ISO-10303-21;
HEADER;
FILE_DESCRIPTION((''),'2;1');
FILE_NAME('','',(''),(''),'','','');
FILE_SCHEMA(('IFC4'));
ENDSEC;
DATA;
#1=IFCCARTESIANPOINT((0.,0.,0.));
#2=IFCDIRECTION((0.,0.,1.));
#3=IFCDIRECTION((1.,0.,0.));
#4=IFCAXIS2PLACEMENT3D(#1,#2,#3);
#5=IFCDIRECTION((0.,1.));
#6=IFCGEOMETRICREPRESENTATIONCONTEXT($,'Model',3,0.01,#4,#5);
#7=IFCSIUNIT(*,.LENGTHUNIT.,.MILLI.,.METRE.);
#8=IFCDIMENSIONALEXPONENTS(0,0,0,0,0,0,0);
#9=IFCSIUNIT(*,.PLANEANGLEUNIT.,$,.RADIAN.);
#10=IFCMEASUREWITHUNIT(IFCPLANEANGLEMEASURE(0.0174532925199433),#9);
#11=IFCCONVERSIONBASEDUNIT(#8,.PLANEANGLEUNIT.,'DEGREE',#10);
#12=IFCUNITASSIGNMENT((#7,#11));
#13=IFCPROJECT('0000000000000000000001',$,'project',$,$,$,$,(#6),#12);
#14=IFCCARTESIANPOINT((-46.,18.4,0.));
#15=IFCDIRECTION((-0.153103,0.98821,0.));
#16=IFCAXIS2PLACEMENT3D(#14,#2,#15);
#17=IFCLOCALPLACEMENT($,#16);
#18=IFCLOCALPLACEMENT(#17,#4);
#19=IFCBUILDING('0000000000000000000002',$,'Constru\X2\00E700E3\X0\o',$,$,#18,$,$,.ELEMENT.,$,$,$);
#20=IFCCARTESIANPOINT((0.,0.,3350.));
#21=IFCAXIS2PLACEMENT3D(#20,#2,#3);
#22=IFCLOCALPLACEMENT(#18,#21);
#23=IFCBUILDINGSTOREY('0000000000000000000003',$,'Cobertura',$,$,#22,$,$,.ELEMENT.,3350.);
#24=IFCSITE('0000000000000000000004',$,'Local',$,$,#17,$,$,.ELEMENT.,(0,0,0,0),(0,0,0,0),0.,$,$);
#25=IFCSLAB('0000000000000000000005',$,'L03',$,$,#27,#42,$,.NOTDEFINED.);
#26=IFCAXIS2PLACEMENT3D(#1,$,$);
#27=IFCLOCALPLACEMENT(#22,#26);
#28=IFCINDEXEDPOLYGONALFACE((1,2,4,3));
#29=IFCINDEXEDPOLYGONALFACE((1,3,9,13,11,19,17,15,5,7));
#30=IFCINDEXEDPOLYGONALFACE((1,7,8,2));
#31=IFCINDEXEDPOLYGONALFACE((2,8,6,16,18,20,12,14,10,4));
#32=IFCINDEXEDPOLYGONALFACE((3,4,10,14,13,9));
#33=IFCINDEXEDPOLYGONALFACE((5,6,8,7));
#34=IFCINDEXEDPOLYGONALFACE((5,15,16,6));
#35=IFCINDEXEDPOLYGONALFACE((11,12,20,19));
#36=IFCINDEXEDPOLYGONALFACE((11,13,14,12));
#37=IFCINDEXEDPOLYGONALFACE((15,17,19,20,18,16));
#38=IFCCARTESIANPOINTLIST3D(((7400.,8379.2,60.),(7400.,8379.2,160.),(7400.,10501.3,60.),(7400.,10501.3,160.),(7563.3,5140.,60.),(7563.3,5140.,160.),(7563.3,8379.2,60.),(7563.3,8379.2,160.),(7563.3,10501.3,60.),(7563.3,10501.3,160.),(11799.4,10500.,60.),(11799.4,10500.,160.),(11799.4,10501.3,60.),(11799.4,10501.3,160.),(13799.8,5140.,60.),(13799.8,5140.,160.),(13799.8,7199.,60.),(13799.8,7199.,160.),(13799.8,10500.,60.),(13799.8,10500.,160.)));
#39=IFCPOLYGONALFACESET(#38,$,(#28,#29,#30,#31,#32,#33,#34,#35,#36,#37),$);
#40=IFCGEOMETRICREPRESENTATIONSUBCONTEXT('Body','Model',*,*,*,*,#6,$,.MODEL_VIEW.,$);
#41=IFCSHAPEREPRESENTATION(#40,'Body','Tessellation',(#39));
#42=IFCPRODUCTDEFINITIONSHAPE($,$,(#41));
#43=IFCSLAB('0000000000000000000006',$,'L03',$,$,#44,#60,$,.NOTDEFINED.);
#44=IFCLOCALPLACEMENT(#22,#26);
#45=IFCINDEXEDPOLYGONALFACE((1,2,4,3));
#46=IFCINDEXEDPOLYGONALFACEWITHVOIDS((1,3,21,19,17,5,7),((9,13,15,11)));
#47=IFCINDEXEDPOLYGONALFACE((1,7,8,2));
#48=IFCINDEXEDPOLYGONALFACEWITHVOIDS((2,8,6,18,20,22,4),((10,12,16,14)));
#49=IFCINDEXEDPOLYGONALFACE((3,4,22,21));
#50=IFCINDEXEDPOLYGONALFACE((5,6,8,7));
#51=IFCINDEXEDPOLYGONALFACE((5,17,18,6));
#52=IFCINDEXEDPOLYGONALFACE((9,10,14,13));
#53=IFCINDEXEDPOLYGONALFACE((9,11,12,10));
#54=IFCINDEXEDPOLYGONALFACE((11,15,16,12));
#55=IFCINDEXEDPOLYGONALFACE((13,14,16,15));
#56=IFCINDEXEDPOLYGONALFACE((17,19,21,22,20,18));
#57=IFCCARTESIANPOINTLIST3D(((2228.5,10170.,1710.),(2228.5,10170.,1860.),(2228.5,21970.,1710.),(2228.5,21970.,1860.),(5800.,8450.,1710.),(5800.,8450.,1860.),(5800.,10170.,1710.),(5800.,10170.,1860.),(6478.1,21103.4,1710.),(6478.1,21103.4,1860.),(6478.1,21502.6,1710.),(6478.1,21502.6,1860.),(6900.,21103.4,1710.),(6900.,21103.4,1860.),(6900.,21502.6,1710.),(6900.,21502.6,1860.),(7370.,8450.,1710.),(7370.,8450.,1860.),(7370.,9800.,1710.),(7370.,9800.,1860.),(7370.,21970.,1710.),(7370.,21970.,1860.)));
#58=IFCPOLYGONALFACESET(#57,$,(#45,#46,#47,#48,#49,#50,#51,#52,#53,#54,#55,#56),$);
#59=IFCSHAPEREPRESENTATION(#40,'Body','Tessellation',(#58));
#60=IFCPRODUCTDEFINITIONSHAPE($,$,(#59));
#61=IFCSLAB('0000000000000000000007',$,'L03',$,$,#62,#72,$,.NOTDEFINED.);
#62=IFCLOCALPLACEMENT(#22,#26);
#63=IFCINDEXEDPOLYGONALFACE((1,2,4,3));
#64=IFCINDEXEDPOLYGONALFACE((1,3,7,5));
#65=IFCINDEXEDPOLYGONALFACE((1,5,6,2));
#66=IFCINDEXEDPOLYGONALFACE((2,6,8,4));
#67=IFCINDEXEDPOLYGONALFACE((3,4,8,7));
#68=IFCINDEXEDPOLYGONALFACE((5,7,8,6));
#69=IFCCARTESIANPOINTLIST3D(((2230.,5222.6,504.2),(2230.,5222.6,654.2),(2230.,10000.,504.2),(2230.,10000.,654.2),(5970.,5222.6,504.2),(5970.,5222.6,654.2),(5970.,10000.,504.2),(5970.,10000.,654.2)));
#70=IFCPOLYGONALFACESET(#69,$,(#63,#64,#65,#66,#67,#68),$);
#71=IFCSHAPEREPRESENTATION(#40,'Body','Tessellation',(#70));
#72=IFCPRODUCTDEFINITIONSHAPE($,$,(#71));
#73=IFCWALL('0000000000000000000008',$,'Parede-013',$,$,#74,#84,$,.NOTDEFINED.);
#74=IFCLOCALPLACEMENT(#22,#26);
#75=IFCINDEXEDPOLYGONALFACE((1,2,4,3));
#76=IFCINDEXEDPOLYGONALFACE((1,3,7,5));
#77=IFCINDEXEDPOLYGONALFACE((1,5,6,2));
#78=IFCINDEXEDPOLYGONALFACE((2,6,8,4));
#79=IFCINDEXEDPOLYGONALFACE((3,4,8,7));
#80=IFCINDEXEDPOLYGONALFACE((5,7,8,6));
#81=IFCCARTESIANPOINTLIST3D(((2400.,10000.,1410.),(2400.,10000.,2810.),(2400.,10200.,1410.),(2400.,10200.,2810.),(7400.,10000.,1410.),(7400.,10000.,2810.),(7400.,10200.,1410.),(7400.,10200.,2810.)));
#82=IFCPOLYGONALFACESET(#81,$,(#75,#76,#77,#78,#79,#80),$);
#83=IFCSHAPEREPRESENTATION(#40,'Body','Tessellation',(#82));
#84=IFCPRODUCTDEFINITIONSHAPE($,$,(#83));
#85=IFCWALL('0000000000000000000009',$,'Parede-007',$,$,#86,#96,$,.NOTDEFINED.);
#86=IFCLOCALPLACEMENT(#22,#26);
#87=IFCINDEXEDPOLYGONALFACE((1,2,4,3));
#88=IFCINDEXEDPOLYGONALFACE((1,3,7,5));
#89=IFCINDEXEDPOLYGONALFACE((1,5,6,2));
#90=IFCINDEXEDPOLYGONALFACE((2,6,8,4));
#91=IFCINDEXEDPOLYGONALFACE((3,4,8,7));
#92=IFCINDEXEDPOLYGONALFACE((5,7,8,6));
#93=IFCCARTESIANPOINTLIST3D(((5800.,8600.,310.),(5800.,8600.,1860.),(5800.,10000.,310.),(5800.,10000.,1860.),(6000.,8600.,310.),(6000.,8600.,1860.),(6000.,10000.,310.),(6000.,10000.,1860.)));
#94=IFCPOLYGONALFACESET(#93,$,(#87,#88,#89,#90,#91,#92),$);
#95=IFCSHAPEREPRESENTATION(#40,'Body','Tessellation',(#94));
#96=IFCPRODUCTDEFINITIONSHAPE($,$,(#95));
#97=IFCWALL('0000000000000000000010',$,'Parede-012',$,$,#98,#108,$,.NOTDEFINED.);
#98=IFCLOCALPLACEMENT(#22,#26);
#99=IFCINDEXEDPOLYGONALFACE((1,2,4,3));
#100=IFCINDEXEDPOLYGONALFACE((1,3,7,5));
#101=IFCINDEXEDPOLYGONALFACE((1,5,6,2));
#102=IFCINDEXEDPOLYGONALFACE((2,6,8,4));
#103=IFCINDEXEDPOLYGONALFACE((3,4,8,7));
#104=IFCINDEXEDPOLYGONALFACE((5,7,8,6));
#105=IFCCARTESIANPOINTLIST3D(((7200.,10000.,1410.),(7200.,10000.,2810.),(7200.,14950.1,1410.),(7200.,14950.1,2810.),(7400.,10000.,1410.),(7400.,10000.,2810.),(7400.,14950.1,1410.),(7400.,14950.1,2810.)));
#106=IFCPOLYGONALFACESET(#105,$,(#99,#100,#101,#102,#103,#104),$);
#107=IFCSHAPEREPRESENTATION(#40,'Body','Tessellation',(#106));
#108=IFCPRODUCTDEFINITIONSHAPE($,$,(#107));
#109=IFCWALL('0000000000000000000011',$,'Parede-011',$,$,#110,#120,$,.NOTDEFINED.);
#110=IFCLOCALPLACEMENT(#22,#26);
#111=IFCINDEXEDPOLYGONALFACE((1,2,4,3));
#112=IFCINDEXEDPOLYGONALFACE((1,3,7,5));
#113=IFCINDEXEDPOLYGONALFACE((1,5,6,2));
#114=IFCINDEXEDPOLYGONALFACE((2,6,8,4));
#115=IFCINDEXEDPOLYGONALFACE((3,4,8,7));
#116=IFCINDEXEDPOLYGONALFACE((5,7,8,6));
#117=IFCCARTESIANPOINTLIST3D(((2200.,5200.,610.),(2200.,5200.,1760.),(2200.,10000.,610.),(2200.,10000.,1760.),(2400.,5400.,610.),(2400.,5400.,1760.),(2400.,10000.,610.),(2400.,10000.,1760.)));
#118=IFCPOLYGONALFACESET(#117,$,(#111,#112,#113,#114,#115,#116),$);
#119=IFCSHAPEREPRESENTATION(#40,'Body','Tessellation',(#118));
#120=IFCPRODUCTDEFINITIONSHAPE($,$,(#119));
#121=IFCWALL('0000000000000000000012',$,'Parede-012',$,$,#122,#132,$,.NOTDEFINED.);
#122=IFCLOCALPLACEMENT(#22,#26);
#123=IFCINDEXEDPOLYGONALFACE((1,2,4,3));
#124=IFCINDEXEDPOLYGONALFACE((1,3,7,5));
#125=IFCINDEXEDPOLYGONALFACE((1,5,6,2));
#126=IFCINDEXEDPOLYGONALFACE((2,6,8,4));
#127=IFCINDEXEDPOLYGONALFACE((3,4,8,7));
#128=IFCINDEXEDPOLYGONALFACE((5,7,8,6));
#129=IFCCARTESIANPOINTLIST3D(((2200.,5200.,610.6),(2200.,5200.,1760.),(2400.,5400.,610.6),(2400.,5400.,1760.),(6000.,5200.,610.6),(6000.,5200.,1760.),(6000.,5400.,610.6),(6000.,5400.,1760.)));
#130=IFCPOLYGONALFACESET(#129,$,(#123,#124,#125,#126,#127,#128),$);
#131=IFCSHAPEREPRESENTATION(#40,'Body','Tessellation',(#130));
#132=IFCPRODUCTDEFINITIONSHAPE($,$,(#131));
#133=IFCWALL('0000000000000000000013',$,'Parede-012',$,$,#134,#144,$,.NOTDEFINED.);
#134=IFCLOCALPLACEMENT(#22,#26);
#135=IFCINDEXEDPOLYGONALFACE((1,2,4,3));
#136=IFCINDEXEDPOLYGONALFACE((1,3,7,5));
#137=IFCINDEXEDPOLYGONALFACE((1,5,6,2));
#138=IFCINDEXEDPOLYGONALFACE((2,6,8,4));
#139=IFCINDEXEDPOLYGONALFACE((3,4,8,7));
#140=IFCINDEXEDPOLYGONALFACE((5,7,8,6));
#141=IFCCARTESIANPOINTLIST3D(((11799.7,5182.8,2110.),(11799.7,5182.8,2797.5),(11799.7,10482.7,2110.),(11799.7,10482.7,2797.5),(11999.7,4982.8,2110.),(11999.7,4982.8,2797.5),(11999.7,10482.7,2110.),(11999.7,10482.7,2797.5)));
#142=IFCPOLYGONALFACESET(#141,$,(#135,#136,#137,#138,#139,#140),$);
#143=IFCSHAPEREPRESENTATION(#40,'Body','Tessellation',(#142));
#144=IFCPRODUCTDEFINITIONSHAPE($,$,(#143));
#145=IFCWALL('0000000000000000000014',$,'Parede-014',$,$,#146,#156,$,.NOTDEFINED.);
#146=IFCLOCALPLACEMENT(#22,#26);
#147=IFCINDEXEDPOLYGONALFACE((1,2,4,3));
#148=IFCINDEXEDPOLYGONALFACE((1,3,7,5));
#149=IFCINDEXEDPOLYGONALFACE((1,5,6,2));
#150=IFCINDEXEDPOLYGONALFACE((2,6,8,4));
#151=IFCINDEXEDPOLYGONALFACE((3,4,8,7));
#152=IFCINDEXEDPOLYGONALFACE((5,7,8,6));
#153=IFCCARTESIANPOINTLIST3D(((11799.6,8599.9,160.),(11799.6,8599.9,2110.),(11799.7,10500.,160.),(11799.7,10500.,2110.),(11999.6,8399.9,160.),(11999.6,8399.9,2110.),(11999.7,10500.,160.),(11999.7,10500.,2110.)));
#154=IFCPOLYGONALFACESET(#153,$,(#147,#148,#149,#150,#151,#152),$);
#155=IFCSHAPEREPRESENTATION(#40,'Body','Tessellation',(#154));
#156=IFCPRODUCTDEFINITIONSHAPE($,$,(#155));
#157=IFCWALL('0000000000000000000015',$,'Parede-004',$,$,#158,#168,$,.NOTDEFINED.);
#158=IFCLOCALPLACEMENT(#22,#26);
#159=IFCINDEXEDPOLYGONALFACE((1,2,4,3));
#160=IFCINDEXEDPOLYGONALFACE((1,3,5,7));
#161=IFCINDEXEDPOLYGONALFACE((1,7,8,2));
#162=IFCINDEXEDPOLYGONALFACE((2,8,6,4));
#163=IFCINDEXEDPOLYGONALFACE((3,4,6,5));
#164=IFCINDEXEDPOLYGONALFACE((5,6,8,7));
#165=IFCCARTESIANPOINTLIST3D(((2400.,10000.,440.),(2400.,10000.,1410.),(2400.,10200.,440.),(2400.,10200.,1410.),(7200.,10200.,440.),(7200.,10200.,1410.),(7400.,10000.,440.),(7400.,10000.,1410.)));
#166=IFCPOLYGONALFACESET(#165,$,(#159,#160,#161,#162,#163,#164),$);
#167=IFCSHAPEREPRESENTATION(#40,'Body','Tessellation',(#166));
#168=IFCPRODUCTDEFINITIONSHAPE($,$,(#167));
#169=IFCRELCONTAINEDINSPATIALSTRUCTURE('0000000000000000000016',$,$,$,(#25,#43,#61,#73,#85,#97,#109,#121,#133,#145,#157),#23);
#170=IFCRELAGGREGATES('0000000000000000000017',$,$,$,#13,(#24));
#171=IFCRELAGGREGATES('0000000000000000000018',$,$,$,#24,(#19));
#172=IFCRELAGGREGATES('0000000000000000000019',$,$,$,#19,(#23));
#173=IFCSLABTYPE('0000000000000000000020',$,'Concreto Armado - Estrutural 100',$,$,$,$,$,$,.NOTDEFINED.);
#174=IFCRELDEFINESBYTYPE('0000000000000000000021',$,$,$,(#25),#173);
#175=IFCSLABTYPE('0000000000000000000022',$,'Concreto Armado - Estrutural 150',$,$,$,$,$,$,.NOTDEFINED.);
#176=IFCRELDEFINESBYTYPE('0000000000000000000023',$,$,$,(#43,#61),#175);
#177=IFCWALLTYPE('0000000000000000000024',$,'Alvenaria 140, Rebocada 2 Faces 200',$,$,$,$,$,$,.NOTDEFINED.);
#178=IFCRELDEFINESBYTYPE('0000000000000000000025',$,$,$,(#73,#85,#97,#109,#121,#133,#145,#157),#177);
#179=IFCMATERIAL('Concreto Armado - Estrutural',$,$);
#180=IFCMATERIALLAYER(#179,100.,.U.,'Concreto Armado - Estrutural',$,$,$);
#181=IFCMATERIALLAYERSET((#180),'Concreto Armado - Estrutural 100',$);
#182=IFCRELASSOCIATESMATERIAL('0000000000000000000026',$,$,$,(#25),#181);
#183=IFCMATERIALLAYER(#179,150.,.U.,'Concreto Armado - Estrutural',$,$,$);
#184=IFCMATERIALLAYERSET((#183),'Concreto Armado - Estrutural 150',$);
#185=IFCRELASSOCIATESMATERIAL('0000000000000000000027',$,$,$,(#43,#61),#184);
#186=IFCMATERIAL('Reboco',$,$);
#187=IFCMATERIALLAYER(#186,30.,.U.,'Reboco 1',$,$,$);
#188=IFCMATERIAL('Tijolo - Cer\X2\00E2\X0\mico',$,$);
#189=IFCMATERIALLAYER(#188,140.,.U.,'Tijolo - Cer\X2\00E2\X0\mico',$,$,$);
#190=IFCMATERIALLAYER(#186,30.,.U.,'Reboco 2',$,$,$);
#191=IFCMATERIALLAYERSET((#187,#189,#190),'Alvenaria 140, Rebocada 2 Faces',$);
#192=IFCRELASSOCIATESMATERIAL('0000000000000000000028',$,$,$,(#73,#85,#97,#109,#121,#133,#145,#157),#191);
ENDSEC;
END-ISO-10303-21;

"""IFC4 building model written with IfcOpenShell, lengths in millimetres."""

from ifc_helpers import new_model, entity, si_unit, converted_unit, direction, frame, origin_with_axes, place, context, subcontext, project, spatial, line, indexed_curve, outline, extrude, material, layer, layer_set, layer_usage, type_object, element, save


model = new_model("IFC4")

# Units and contexts
model_context = context("Model", 3, precision=0.01, world=origin_with_axes(), true_north=direction((0.0, 1.0)))
body_context = subcontext(model_context, "Body", "Model", "MODEL_VIEW")
ifc_project = project(units=[si_unit("LENGTHUNIT", "METRE", prefix="MILLI"), converted_unit("PLANEANGLEUNIT", "DEGREE", entity("IfcPlaneAngleMeasure", 0.0174532925199433), si_unit("PLANEANGLEUNIT", "RADIAN"), dimensions=[0, 0, 0, 0, 0, 0, 0])], contexts=[model_context])

# Site, building, storey
site_placement = place(None, frame((-46.0, 18.4, 0.0), z_axis=(0.0, 0.0, 1.0), x_axis=(-0.153103, 0.98821, 0.0)))
site = spatial("IfcSite", under=ifc_project, at=site_placement, Name="Local", CompositionType="ELEMENT", RefLatitude=(0, 0, 0, 0), RefLongitude=(0, 0, 0, 0), RefElevation=0.0)
building_placement = place(site_placement, origin_with_axes())
building = spatial("IfcBuilding", under=site, at=building_placement, Name="Construção", CompositionType="ELEMENT")
storey_placement = place(building_placement, frame((0.0, 0.0, 3350.0), z_axis=(0.0, 0.0, 1.0), x_axis=(1.0, 0.0, 0.0)))
storey = spatial("IfcBuildingStorey", under=building, at=storey_placement, Name="Cobertura", CompositionType="ELEMENT", Elevation=3350.0)

# Shared definitions
ifc_material_1 = material(Name="Concreto Armado - Estrutural")

# Slabs
ifc_layer_1 = layer(ifc_material_1, 100.0, ventilated="UNKNOWN", Name="Concreto Armado - Estrutural")
ifc_layer_set_1 = layer_set([ifc_layer_1], Name="Concreto Armado - Estrutural 100")
ifc_layer_usage_1 = layer_usage(ifc_layer_set_1, "AXIS3", "NEGATIVE", 100.0)
slab_type_1 = type_object("IfcSlabType", Name="Concreto Armado - Estrutural 100", PredefinedType="NOTDEFINED")
slab_1_placement = place(storey_placement, frame((7400.0, 8379.2, 160.0), z_axis=(0.0, 0.0, 1.0), x_axis=(1.0, 0.0, 0.0)))
element("IfcSlab", 1, at=slab_1_placement, inside=storey, type_object=slab_type_1, material=ifc_layer_usage_1, Name="L03", PredefinedType="NOTDEFINED", context=body_context, shape_type="SweptSolid", body=[
    extrude(outline(indexed_curve([(0.0, 0.0), (163.3, 0.0), (163.3, -3239.2), (6399.9, -3239.2), (6399.9, -1180.2), (6399.9, 2120.8), (4399.4, 2120.8), (4399.4, 2122.1), (163.3, 2122.1), (0.0, 2122.1)], segments=[line(1, 2, 3, 4, 5, 6, 7, 8, 9, 10, 1)])), frame((0.0, 0.0, -100.0), z_axis=(0.0, 0.0, 1.0), x_axis=(1.0, 0.0, 0.0)), (0.0, 0.0, 1.0), 100.0),
])
ifc_layer_2 = layer(ifc_material_1, 150.0, ventilated="UNKNOWN", Name="Concreto Armado - Estrutural")
ifc_layer_set_2 = layer_set([ifc_layer_2], Name="Concreto Armado - Estrutural 150")
ifc_layer_usage_2 = layer_usage(ifc_layer_set_2, "AXIS3", "NEGATIVE", 150.0)
slab_type_2 = type_object("IfcSlabType", Name="Concreto Armado - Estrutural 150", PredefinedType="NOTDEFINED")
slab_2_placement = place(storey_placement, frame((2228.5, 10170.0, 1860.0), z_axis=(0.0, 0.0, 1.0), x_axis=(1.0, 0.0, 0.0)))
element("IfcSlab", 2, at=slab_2_placement, inside=storey, type_object=slab_type_2, material=ifc_layer_usage_2, Name="L03", PredefinedType="NOTDEFINED", context=body_context, shape_type="SweptSolid", body=[
    extrude(outline(indexed_curve([(0.0, 0.0), (3571.5, 0.0), (3571.5, -1720.0), (5141.5, -1720.0), (5141.5, -370.0), (5141.5, 11800.0), (0.0, 11800.0), (4249.6, 10933.4), (4249.6, 11332.6), (4671.5, 11332.6), (4671.5, 10933.4)], segments=[line(1, 2, 3, 4, 5, 6, 7, 1)]), holes=[indexed_curve([(0.0, 0.0), (3571.5, 0.0), (3571.5, -1720.0), (5141.5, -1720.0), (5141.5, -370.0), (5141.5, 11800.0), (0.0, 11800.0), (4249.6, 10933.4), (4249.6, 11332.6), (4671.5, 11332.6), (4671.5, 10933.4)], segments=[line(8, 9, 10, 11, 8)])]), frame((0.0, 0.0, -150.0), z_axis=(0.0, 0.0, 1.0), x_axis=(1.0, 0.0, 0.0)), (0.0, 0.0, 1.0), 150.0),
])
ifc_layer_usage_3 = layer_usage(ifc_layer_set_2, "AXIS3", "NEGATIVE", 150.0)
slab_3_placement = place(storey_placement, frame((2230.0, 5222.6, 654.2), z_axis=(0.0, 0.0, 1.0), x_axis=(1.0, 0.0, 0.0)))
element("IfcSlab", 3, at=slab_3_placement, inside=storey, type_object=slab_type_2, material=ifc_layer_usage_3, Name="L03", PredefinedType="NOTDEFINED", context=body_context, shape_type="SweptSolid", body=[
    extrude(outline(indexed_curve([(0.0, 0.0), (3740.0, 0.0), (3740.0, 4777.5), (0.0, 4777.5)], segments=[line(1, 2, 3, 4, 1)])), frame((0.0, 0.0, -150.0), z_axis=(0.0, 0.0, 1.0), x_axis=(1.0, 0.0, 0.0)), (0.0, 0.0, 1.0), 150.0),
])

# Walls
ifc_material_2 = material(Name="Reboco")
ifc_layer_3 = layer(ifc_material_2, 30.0, ventilated="UNKNOWN", Name="Reboco 1")
ifc_material_3 = material(Name="Tijolo - Cerâmico")
ifc_layer_4 = layer(ifc_material_3, 140.0, ventilated="UNKNOWN", Name="Tijolo - Cerâmico")
ifc_layer_5 = layer(ifc_material_2, 30.0, ventilated="UNKNOWN", Name="Reboco 2")
ifc_layer_set_3 = layer_set([ifc_layer_3, ifc_layer_4, ifc_layer_5], Name="Alvenaria 140, Rebocada 2 Faces")
ifc_layer_usage_4 = layer_usage(ifc_layer_set_3, "AXIS2", "NEGATIVE", 0.0)
wall_type_1 = type_object("IfcWallType", Name="Alvenaria 140, Rebocada 2 Faces 200", PredefinedType="NOTDEFINED")
wall_1_placement = place(storey_placement, frame((7400.0, 10000.0, 1410.0), z_axis=(0.0, 0.0, 1.0), x_axis=(-1.0, 0.0, 0.0)))
element("IfcWall", 4, at=wall_1_placement, inside=storey, type_object=wall_type_1, material=ifc_layer_usage_4, Name="Parede-013", PredefinedType="NOTDEFINED", context=body_context, shape_type="SweptSolid", body=[
    extrude(outline(indexed_curve([(0.0, -200.0), (5000.0, -200.0), (5000.0, 0.0), (0.0, 0.0)], segments=[line(1, 2, 3, 4, 1)])), origin_with_axes(), (0.0, 0.0, 1.0), 1400.0),
])
ifc_layer_usage_5 = layer_usage(ifc_layer_set_3, "AXIS2", "POSITIVE", 0.0)
wall_2_placement = place(storey_placement, frame((6000.0, 8600.0, 310.0), z_axis=(0.0, 0.0, 1.0), x_axis=(0.000007, 1.0, 0.0)))
element("IfcWall", 5, at=wall_2_placement, inside=storey, type_object=wall_type_1, material=ifc_layer_usage_5, Name="Parede-007", PredefinedType="NOTDEFINED", context=body_context, shape_type="SweptSolid", body=[
    extrude(outline(indexed_curve([(0.0, 0.0), (1400.0, 0.0), (1400.0, 200.0), (0.0, 200.0)], segments=[line(1, 2, 3, 4, 1)])), origin_with_axes(), (0.0, 0.0, 1.0), 1550.0),
])
ifc_layer_usage_6 = layer_usage(ifc_layer_set_3, "AXIS2", "POSITIVE", 0.0)
wall_3_placement = place(storey_placement, frame((7400.0, 10000.0, 1410.0), z_axis=(0.0, 0.0, 1.0), x_axis=(0.0, 1.0, 0.0)))
element("IfcWall", 6, at=wall_3_placement, inside=storey, type_object=wall_type_1, material=ifc_layer_usage_6, Name="Parede-012", PredefinedType="NOTDEFINED", context=body_context, shape_type="SweptSolid", body=[
    extrude(outline(indexed_curve([(0.0, 0.0), (4950.0, 0.0), (4950.0, 200.0), (0.0, 200.0)], segments=[line(1, 2, 3, 4, 1)])), origin_with_axes(), (0.0, 0.0, 1.0), 1400.0),
])
ifc_layer_usage_7 = layer_usage(ifc_layer_set_3, "AXIS2", "POSITIVE", 0.0)
wall_4_placement = place(storey_placement, frame((2200.0, 10000.0, 610.0), z_axis=(0.0, 0.0, 1.0), x_axis=(0.0, -1.0, 0.0)))
element("IfcWall", 7, at=wall_4_placement, inside=storey, type_object=wall_type_1, material=ifc_layer_usage_7, Name="Parede-011", PredefinedType="NOTDEFINED", context=body_context, shape_type="SweptSolid", body=[
    extrude(outline(indexed_curve([(0.0, 0.0), (4800.0, 0.0), (4600.0, 200.0), (0.0, 200.0)], segments=[line(1, 2, 3, 4, 1)])), origin_with_axes(), (0.0, 0.0, 1.0), 1150.0),
])
ifc_layer_usage_8 = layer_usage(ifc_layer_set_3, "AXIS2", "POSITIVE", 0.0)
wall_5_placement = place(storey_placement, frame((2200.0, 5200.0, 610.6), z_axis=(0.0, 0.0, 1.0), x_axis=(1.0, 0.000002, 0.0)))
element("IfcWall", 8, at=wall_5_placement, inside=storey, type_object=wall_type_1, material=ifc_layer_usage_8, Name="Parede-012", PredefinedType="NOTDEFINED", context=body_context, shape_type="SweptSolid", body=[
    extrude(outline(indexed_curve([(0.0, 0.0), (3800.0, 0.0), (3800.0, 200.0), (200.0, 200.0)], segments=[line(1, 2, 3, 4, 1)])), origin_with_axes(), (0.0, 0.0, 1.0), 1149.4),
])
ifc_layer_usage_9 = layer_usage(ifc_layer_set_3, "AXIS2", "POSITIVE", 0.0)
wall_6_placement = place(storey_placement, frame((11999.7, 4982.8, 2110.0), z_axis=(0.0, 0.0, 1.0), x_axis=(-0.000001, 1.0, 0.0)))
element("IfcWall", 9, at=wall_6_placement, inside=storey, type_object=wall_type_1, material=ifc_layer_usage_9, Name="Parede-012", PredefinedType="NOTDEFINED", context=body_context, shape_type="SweptSolid", body=[
    extrude(outline(indexed_curve([(0.0, 0.0), (5500.0, 0.0), (5500.0, 200.0), (200.0, 200.0)], segments=[line(1, 2, 3, 4, 1)])), origin_with_axes(), (0.0, 0.0, 1.0), 687.5),
])
ifc_layer_usage_10 = layer_usage(ifc_layer_set_3, "AXIS2", "POSITIVE", 0.0)
wall_7_placement = place(storey_placement, frame((11999.6, 8399.9, 160.0), z_axis=(0.0, 0.0, 1.0), x_axis=(0.00003, 1.0, 0.0)))
element("IfcWall", 10, at=wall_7_placement, inside=storey, type_object=wall_type_1, material=ifc_layer_usage_10, Name="Parede-014", PredefinedType="NOTDEFINED", context=body_context, shape_type="SweptSolid", body=[
    extrude(outline(indexed_curve([(0.0, 0.0), (2100.1, 0.0), (2100.1, 200.0), (200.0, 200.0)], segments=[line(1, 2, 3, 4, 1)])), origin_with_axes(), (0.0, 0.0, 1.0), 1950.0),
])
ifc_layer_usage_11 = layer_usage(ifc_layer_set_3, "AXIS2", "POSITIVE", 0.0)
wall_8_placement = place(storey_placement, frame((2200.0, 10000.0, 440.0), z_axis=(0.0, 0.0, 1.0), x_axis=(1.0, 0.0, 0.0)))
element("IfcWall", 11, at=wall_8_placement, inside=storey, type_object=wall_type_1, material=ifc_layer_usage_11, Name="Parede-004", PredefinedType="NOTDEFINED", context=body_context, shape_type="SweptSolid", body=[
    extrude(outline(indexed_curve([(200.0, 0.0), (5200.0, 0.0), (5000.0, 200.0), (200.0, 200.0)], segments=[line(1, 2, 3, 4, 1)])), origin_with_axes(), (0.0, 0.0, 1.0), 970.0),
])

save(model, "model.ifc")
